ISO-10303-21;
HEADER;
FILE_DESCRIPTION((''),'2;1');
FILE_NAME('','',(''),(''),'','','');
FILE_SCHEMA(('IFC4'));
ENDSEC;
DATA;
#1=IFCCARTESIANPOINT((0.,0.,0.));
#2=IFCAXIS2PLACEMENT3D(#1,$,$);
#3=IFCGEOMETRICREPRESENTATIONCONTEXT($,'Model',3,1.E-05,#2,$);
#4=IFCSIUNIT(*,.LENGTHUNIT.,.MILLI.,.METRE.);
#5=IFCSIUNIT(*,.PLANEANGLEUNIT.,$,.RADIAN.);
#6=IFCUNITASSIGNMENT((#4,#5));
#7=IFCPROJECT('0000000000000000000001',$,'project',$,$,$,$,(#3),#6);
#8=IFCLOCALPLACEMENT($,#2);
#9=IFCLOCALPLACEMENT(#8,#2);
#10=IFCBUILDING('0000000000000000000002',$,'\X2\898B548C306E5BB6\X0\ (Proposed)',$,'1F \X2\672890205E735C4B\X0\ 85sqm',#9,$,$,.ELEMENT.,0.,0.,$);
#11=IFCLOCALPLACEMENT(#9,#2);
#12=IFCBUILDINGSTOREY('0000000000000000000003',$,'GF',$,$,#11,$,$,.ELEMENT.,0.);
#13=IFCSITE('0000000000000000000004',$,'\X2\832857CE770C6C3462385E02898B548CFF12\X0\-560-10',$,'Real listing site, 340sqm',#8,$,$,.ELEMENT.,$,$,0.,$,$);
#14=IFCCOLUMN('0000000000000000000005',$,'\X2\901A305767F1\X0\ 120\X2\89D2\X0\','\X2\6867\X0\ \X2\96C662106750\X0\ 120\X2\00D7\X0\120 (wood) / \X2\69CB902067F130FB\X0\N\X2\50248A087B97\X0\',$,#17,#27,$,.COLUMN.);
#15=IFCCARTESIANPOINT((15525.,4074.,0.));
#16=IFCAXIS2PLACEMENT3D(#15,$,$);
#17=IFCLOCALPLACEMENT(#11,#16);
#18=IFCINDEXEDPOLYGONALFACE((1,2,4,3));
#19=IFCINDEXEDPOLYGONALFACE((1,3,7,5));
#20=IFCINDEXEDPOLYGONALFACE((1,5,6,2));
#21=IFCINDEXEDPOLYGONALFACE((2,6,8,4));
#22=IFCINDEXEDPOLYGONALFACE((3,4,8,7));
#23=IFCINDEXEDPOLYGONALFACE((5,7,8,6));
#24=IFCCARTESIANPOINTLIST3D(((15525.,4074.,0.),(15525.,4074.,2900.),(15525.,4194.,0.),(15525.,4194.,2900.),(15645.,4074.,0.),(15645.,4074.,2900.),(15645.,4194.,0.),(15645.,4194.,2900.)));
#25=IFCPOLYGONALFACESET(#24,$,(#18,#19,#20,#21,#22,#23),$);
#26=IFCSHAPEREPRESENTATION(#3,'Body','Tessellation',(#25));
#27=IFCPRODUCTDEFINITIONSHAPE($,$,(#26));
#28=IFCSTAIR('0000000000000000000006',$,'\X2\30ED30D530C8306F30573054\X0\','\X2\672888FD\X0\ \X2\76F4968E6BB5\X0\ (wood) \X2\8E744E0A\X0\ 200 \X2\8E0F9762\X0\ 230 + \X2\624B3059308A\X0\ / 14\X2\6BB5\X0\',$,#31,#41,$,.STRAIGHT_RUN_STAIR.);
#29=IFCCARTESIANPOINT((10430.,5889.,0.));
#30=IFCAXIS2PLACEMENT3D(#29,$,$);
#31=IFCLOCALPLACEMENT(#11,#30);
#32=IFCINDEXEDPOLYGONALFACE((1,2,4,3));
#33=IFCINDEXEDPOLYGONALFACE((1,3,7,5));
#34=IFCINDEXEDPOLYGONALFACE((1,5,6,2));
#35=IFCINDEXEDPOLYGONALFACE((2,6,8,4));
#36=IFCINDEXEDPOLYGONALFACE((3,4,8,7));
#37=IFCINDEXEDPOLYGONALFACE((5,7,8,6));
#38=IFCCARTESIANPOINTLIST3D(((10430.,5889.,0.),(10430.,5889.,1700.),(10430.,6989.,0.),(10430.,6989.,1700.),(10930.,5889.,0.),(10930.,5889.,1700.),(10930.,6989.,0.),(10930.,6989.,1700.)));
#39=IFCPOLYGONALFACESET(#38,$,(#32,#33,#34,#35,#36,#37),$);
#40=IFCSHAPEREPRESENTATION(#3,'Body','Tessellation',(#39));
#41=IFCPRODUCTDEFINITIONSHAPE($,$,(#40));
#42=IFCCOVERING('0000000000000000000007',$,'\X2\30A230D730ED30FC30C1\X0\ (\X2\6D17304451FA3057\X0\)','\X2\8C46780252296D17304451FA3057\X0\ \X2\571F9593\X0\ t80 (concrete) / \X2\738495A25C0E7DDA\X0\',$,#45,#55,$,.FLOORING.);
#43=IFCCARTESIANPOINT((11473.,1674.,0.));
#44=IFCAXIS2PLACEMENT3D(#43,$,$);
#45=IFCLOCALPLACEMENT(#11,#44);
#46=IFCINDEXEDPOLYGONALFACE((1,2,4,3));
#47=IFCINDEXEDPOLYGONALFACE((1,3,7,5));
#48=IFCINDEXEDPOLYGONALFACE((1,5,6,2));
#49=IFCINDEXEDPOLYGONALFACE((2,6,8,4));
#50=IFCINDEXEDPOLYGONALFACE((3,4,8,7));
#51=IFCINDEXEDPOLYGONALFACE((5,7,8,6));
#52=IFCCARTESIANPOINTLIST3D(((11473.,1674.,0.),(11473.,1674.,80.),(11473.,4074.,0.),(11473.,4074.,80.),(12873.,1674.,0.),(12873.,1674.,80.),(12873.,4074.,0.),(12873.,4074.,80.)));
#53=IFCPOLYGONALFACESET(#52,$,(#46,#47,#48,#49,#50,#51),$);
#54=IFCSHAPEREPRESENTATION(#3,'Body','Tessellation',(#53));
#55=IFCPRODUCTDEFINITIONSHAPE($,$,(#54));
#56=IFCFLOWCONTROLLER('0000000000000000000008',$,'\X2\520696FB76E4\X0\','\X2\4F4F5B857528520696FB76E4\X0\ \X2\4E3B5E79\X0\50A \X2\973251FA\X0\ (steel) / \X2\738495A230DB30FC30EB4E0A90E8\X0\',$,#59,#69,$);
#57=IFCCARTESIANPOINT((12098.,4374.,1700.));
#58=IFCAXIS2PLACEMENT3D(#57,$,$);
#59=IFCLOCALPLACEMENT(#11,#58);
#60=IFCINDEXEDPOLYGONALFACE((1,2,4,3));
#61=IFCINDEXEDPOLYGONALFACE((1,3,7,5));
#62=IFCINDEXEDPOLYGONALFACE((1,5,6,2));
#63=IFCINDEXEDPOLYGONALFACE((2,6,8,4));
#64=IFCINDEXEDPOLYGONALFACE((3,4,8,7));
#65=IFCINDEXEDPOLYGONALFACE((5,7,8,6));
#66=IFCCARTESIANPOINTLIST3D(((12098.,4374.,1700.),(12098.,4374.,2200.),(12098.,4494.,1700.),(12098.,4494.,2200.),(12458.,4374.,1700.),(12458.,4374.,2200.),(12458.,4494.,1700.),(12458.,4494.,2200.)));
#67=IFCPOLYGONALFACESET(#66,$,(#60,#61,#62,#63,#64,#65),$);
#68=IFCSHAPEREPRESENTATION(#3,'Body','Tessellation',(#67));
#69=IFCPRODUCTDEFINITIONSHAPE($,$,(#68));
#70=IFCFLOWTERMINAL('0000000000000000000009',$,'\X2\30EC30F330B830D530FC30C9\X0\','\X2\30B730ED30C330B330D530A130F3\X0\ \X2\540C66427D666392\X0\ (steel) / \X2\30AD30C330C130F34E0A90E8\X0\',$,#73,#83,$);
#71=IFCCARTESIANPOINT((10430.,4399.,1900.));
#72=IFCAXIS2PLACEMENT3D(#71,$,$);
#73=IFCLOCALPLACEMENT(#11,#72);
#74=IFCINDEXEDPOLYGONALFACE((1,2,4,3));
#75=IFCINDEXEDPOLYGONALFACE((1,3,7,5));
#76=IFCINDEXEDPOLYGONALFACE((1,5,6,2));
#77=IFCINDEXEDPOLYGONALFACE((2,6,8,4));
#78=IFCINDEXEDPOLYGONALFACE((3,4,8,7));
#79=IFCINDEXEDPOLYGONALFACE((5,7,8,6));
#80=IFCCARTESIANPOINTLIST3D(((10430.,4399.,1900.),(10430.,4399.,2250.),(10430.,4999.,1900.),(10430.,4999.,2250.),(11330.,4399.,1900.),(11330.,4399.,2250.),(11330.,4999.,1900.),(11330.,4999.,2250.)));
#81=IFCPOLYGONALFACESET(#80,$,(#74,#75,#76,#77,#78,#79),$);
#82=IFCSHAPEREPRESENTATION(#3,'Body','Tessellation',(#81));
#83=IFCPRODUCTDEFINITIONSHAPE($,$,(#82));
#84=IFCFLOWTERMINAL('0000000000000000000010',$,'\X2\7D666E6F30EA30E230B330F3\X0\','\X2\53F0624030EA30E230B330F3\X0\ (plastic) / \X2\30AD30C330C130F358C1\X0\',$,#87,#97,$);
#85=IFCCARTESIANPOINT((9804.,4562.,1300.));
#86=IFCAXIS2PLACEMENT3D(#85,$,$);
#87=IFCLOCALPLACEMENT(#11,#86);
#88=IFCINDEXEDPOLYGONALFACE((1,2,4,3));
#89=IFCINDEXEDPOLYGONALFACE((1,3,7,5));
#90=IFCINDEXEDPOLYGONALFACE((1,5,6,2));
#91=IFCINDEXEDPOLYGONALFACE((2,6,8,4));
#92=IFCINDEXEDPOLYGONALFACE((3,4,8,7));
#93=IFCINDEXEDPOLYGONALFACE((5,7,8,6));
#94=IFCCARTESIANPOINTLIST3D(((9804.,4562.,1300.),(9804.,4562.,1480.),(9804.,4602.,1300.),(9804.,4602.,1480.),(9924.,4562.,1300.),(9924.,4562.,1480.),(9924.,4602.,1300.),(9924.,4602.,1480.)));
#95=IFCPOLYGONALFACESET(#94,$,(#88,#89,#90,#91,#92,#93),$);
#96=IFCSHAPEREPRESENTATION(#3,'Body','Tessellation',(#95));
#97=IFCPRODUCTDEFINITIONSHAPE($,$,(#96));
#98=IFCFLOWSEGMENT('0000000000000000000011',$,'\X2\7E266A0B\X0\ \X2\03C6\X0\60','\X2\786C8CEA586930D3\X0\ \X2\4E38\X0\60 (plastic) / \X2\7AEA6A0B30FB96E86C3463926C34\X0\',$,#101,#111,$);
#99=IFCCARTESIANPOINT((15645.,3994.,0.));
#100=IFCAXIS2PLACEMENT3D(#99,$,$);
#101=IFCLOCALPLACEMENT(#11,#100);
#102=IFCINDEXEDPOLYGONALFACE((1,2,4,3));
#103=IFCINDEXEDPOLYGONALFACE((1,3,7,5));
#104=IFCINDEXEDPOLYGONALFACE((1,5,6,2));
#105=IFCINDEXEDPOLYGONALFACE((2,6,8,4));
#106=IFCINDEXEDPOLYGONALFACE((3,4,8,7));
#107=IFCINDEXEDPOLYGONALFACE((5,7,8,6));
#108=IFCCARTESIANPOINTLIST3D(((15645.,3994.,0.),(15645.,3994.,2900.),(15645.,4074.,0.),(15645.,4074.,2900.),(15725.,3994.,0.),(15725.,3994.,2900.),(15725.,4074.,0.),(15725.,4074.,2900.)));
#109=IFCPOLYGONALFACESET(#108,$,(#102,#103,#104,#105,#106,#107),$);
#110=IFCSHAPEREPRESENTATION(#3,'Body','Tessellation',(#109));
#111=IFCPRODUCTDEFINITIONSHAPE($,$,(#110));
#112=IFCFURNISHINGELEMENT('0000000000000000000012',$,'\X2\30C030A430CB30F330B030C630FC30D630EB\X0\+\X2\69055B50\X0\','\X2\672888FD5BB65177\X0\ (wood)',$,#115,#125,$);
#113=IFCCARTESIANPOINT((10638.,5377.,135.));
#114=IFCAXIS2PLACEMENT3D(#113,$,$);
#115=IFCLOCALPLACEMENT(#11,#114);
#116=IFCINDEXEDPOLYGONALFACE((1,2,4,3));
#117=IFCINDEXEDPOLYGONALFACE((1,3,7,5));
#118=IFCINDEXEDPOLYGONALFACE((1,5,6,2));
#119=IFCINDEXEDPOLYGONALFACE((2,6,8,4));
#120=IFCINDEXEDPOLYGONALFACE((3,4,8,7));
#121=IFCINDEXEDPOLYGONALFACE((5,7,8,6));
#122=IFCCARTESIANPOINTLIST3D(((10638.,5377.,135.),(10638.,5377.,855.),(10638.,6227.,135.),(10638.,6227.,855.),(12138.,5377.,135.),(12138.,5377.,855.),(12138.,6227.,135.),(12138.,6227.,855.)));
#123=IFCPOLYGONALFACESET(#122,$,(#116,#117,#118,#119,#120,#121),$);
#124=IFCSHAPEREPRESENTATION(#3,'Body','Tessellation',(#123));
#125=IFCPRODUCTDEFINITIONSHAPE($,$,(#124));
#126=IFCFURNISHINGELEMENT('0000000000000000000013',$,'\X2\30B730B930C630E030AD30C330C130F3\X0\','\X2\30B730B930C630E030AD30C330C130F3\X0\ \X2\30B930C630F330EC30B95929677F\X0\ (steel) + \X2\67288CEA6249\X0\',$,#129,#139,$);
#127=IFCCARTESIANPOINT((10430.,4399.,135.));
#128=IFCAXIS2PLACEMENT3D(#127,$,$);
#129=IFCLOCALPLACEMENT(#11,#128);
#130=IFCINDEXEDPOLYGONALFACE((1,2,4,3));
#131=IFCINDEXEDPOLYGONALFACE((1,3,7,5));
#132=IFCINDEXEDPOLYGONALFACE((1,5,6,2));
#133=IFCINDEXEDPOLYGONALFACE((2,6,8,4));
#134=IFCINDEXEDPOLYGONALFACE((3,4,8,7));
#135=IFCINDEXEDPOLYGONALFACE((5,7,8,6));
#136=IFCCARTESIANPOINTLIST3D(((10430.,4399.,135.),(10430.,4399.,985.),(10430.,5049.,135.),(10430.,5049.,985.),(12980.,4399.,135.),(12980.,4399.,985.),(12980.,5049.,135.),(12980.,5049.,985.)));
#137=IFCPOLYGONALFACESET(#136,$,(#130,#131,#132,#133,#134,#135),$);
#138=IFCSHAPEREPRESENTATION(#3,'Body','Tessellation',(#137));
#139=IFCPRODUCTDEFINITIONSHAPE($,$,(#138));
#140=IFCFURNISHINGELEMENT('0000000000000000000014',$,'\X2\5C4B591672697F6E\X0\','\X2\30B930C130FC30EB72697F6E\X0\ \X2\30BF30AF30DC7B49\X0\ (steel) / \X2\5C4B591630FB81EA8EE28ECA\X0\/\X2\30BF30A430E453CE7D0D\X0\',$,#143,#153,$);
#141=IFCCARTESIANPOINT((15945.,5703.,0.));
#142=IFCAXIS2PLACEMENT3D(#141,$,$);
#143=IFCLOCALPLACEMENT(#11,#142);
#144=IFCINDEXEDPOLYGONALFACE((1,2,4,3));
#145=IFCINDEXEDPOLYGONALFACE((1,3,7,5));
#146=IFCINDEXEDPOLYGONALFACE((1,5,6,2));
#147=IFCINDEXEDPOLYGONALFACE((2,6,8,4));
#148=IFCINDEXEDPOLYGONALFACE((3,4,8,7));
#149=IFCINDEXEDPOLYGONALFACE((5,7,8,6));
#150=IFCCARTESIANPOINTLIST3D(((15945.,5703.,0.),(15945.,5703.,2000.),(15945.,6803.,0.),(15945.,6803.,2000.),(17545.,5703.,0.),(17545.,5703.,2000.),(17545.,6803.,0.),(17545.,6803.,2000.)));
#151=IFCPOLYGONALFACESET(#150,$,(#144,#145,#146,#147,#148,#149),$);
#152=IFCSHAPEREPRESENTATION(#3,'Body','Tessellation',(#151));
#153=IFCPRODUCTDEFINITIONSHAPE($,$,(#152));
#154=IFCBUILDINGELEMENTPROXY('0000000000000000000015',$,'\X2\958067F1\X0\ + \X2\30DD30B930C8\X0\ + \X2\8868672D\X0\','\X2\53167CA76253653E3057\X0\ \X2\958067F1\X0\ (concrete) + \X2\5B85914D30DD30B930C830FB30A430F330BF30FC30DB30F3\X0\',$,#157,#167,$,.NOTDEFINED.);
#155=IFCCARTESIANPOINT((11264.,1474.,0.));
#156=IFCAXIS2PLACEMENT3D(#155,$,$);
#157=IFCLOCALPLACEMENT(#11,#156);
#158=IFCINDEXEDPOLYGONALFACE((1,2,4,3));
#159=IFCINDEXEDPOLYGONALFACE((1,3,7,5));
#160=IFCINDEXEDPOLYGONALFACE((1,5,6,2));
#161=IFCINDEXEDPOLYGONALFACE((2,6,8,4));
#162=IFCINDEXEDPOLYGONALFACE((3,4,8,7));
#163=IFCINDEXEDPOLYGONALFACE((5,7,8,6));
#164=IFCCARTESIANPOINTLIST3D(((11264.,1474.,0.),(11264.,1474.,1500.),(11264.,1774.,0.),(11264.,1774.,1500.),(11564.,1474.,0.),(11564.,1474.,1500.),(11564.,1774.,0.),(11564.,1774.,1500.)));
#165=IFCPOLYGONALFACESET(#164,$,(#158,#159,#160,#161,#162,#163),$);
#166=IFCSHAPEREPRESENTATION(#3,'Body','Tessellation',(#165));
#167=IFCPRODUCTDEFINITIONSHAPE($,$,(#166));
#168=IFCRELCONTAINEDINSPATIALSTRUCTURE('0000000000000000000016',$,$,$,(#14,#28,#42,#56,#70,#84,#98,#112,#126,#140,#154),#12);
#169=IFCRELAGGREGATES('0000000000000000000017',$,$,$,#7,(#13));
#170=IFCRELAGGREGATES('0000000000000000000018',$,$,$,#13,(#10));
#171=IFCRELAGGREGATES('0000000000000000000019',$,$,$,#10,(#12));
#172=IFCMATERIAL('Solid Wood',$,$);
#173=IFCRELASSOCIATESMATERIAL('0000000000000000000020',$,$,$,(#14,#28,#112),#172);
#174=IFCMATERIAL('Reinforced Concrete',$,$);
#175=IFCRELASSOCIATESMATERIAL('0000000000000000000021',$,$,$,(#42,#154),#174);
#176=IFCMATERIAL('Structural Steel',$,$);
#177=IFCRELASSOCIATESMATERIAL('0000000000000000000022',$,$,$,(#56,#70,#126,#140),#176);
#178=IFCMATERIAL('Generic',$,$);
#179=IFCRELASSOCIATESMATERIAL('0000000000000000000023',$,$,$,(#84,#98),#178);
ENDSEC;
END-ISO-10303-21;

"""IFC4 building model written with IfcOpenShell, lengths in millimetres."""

from ifc_helpers import new_model, si_unit, frame, frame_2d, origin, place, context, project, spatial, rectangle, extrude, material, element, save


model = new_model("IFC4")

# Units and contexts
model_context = context("Model", 3, precision=1e-05, world=origin())
ifc_project = project(units=[si_unit("LENGTHUNIT", "METRE", prefix="MILLI"), si_unit("PLANEANGLEUNIT", "RADIAN")], contexts=[model_context])

# Site, building, storey
site_placement = place(None, origin())
site = spatial("IfcSite", under=ifc_project, at=site_placement, Name="茨城県水戸市見和２-560-10", ObjectType="Real listing site, 340sqm", CompositionType="ELEMENT", RefElevation=0.0)
building_placement = place(site_placement, origin())
building = spatial("IfcBuilding", under=site, at=building_placement, Name="見和の家 (Proposed)", ObjectType="1F 木造平屋 85sqm", CompositionType="ELEMENT", ElevationOfRefHeight=0.0, ElevationOfTerrain=0.0)
storey_placement = place(building_placement, origin())
storey = spatial("IfcBuildingStorey", under=building, at=storey_placement, Name="GF", CompositionType="ELEMENT", Elevation=0.0)

# Column
ifc_material_1 = material(Name="Solid Wood")
column_1_placement = place(storey_placement, frame((15525.0, 4074.0, 0.0)))
element("IfcColumn", 1, at=column_1_placement, inside=storey, material=ifc_material_1, Name="通し柱 120角", Description="桧 集成材 120×120 (wood) / 構造柱・N値計算", PredefinedType="COLUMN", context=model_context, shape_type="SweptSolid", body=[
    extrude(rectangle(XDim=120.0, YDim=120.0, at=frame_2d((60.0, 60.0))), frame((15525.0, 4074.0, 0.0)), (0.0, 0.0, 1.0), 2900.0),
])

# Stair
stair_placement = place(storey_placement, frame((10430.0, 5889.0, 0.0)))
element("IfcStair", 2, at=stair_placement, inside=storey, material=ifc_material_1, Name="ロフトはしご", Description="木製 直階段 (wood) 蹴上 200 踏面 230 + 手すり / 14段", PredefinedType="STRAIGHT_RUN_STAIR", context=model_context, shape_type="SweptSolid", body=[
    extrude(rectangle(XDim=500.0, YDim=1100.0, at=frame_2d((250.0, 550.0))), frame((10430.0, 5889.0, 0.0)), (0.0, 0.0, 1.0), 1700.0),
])

# Covering
ifc_material_2 = material(Name="Reinforced Concrete")
covering_placement = place(storey_placement, frame((11473.0, 1674.0, 0.0)))
element("IfcCovering", 3, at=covering_placement, inside=storey, material=ifc_material_2, Name="アプローチ (洗い出し)", Description="豆砂利洗い出し 土間 t80 (concrete) / 玄関導線", PredefinedType="FLOORING", context=model_context, shape_type="SweptSolid", body=[
    extrude(rectangle(XDim=1400.0, YDim=2400.0, at=frame_2d((700.0, 1200.0))), frame((11473.0, 1674.0, 0.0)), (0.0, 0.0, 1.0), 80.0),
])

# Flow controller
ifc_material_3 = material(Name="Structural Steel")
flow_controller_placement = place(storey_placement, frame((12098.0, 4374.0, 1700.0)))
element("IfcFlowController", 4, at=flow_controller_placement, inside=storey, material=ifc_material_3, Name="分電盤", Description="住宅用分電盤 主幹50A 露出 (steel) / 玄関ホール上部", context=model_context, shape_type="SweptSolid", body=[
    extrude(rectangle(XDim=360.0, YDim=120.0, at=frame_2d((180.0, 60.0))), frame((12098.0, 4374.0, 1700.0)), (0.0, 0.0, 1.0), 500.0),
])

# Flow terminals
flow_terminal_1_placement = place(storey_placement, frame((10430.0, 4399.0, 1900.0)))
element("IfcFlowTerminal", 5, at=flow_terminal_1_placement, inside=storey, material=ifc_material_3, Name="レンジフード", Description="シロッコファン 同時給排 (steel) / キッチン上部", context=model_context, shape_type="SweptSolid", body=[
    extrude(rectangle(XDim=900.0, YDim=600.0, at=frame_2d((450.0, 300.0))), frame((10430.0, 4399.0, 1900.0)), (0.0, 0.0, 1.0), 350.0),
])
ifc_material_4 = material(Name="Generic")
flow_terminal_2_placement = place(storey_placement, frame((9804.0, 4562.0, 1300.0)))
element("IfcFlowTerminal", 6, at=flow_terminal_2_placement, inside=storey, material=ifc_material_4, Name="給湯リモコン", Description="台所リモコン (plastic) / キッチン壁", context=model_context, shape_type="SweptSolid", body=[
    extrude(rectangle(XDim=120.0, YDim=40.0, at=frame_2d((60.0, 20.0))), frame((9804.0, 4562.0, 1300.0)), (0.0, 0.0, 1.0), 180.0),
])

# Flow segment
flow_segment_placement = place(storey_placement, frame((15645.0, 3994.0, 0.0)))
element("IfcFlowSegment", 7, at=flow_segment_placement, inside=storey, material=ifc_material_4, Name="縦樋 φ60", Description="硬質塩ビ 丸60 (plastic) / 竪樋・雨水排水", context=model_context, shape_type="SweptSolid", body=[
    extrude(rectangle(XDim=80.0, YDim=80.0, at=frame_2d((40.0, 40.0))), frame((15645.0, 3994.0, 0.0)), (0.0, 0.0, 1.0), 2900.0),
])

# Furnishing elements
furnishing_1_placement = place(storey_placement, frame((10638.0, 5377.0, 135.0)))
element("IfcFurnishingElement", 8, at=furnishing_1_placement, inside=storey, material=ifc_material_1, Name="ダイニングテーブル+椅子", Description="木製家具 (wood)", context=model_context, shape_type="SweptSolid", body=[
    extrude(rectangle(XDim=1500.0, YDim=850.0, at=frame_2d((750.0, 425.0))), frame((10638.0, 5377.0, 135.0)), (0.0, 0.0, 1.0), 720.0),
])
furnishing_2_placement = place(storey_placement, frame((10430.0, 4399.0, 135.0)))
element("IfcFurnishingElement", 9, at=furnishing_2_placement, inside=storey, material=ifc_material_3, Name="システムキッチン", Description="システムキッチン ステンレス天板 (steel) + 木質扉", context=model_context, shape_type="SweptSolid", body=[
    extrude(rectangle(XDim=2550.0, YDim=650.0, at=frame_2d((1275.0, 325.0))), frame((10430.0, 4399.0, 135.0)), (0.0, 0.0, 1.0), 850.0),
])
furnishing_3_placement = place(storey_placement, frame((15945.0, 5703.0, 0.0)))
element("IfcFurnishingElement", 10, at=furnishing_3_placement, inside=storey, material=ifc_material_3, Name="屋外物置", Description="スチール物置 タクボ等 (steel) / 屋外・自転車/タイヤ収納", context=model_context, shape_type="SweptSolid", body=[
    extrude(rectangle(XDim=1600.0, YDim=1100.0, at=frame_2d((800.0, 550.0))), frame((15945.0, 5703.0, 0.0)), (0.0, 0.0, 1.0), 2000.0),
])

# Building element proxy
proxy_placement = place(storey_placement, frame((11264.0, 1474.0, 0.0)))
element("IfcBuildingElementProxy", 11, at=proxy_placement, inside=storey, material=ifc_material_2, Name="門柱 + ポスト + 表札", Description="化粧打放し 門柱 (concrete) + 宅配ポスト・インターホン", PredefinedType="NOTDEFINED", context=model_context, shape_type="SweptSolid", body=[
    extrude(rectangle(XDim=300.0, YDim=300.0, at=frame_2d((150.0, 150.0))), frame((11264.0, 1474.0, 0.0)), (0.0, 0.0, 1.0), 1500.0),
])

save(model, "model.ifc")
